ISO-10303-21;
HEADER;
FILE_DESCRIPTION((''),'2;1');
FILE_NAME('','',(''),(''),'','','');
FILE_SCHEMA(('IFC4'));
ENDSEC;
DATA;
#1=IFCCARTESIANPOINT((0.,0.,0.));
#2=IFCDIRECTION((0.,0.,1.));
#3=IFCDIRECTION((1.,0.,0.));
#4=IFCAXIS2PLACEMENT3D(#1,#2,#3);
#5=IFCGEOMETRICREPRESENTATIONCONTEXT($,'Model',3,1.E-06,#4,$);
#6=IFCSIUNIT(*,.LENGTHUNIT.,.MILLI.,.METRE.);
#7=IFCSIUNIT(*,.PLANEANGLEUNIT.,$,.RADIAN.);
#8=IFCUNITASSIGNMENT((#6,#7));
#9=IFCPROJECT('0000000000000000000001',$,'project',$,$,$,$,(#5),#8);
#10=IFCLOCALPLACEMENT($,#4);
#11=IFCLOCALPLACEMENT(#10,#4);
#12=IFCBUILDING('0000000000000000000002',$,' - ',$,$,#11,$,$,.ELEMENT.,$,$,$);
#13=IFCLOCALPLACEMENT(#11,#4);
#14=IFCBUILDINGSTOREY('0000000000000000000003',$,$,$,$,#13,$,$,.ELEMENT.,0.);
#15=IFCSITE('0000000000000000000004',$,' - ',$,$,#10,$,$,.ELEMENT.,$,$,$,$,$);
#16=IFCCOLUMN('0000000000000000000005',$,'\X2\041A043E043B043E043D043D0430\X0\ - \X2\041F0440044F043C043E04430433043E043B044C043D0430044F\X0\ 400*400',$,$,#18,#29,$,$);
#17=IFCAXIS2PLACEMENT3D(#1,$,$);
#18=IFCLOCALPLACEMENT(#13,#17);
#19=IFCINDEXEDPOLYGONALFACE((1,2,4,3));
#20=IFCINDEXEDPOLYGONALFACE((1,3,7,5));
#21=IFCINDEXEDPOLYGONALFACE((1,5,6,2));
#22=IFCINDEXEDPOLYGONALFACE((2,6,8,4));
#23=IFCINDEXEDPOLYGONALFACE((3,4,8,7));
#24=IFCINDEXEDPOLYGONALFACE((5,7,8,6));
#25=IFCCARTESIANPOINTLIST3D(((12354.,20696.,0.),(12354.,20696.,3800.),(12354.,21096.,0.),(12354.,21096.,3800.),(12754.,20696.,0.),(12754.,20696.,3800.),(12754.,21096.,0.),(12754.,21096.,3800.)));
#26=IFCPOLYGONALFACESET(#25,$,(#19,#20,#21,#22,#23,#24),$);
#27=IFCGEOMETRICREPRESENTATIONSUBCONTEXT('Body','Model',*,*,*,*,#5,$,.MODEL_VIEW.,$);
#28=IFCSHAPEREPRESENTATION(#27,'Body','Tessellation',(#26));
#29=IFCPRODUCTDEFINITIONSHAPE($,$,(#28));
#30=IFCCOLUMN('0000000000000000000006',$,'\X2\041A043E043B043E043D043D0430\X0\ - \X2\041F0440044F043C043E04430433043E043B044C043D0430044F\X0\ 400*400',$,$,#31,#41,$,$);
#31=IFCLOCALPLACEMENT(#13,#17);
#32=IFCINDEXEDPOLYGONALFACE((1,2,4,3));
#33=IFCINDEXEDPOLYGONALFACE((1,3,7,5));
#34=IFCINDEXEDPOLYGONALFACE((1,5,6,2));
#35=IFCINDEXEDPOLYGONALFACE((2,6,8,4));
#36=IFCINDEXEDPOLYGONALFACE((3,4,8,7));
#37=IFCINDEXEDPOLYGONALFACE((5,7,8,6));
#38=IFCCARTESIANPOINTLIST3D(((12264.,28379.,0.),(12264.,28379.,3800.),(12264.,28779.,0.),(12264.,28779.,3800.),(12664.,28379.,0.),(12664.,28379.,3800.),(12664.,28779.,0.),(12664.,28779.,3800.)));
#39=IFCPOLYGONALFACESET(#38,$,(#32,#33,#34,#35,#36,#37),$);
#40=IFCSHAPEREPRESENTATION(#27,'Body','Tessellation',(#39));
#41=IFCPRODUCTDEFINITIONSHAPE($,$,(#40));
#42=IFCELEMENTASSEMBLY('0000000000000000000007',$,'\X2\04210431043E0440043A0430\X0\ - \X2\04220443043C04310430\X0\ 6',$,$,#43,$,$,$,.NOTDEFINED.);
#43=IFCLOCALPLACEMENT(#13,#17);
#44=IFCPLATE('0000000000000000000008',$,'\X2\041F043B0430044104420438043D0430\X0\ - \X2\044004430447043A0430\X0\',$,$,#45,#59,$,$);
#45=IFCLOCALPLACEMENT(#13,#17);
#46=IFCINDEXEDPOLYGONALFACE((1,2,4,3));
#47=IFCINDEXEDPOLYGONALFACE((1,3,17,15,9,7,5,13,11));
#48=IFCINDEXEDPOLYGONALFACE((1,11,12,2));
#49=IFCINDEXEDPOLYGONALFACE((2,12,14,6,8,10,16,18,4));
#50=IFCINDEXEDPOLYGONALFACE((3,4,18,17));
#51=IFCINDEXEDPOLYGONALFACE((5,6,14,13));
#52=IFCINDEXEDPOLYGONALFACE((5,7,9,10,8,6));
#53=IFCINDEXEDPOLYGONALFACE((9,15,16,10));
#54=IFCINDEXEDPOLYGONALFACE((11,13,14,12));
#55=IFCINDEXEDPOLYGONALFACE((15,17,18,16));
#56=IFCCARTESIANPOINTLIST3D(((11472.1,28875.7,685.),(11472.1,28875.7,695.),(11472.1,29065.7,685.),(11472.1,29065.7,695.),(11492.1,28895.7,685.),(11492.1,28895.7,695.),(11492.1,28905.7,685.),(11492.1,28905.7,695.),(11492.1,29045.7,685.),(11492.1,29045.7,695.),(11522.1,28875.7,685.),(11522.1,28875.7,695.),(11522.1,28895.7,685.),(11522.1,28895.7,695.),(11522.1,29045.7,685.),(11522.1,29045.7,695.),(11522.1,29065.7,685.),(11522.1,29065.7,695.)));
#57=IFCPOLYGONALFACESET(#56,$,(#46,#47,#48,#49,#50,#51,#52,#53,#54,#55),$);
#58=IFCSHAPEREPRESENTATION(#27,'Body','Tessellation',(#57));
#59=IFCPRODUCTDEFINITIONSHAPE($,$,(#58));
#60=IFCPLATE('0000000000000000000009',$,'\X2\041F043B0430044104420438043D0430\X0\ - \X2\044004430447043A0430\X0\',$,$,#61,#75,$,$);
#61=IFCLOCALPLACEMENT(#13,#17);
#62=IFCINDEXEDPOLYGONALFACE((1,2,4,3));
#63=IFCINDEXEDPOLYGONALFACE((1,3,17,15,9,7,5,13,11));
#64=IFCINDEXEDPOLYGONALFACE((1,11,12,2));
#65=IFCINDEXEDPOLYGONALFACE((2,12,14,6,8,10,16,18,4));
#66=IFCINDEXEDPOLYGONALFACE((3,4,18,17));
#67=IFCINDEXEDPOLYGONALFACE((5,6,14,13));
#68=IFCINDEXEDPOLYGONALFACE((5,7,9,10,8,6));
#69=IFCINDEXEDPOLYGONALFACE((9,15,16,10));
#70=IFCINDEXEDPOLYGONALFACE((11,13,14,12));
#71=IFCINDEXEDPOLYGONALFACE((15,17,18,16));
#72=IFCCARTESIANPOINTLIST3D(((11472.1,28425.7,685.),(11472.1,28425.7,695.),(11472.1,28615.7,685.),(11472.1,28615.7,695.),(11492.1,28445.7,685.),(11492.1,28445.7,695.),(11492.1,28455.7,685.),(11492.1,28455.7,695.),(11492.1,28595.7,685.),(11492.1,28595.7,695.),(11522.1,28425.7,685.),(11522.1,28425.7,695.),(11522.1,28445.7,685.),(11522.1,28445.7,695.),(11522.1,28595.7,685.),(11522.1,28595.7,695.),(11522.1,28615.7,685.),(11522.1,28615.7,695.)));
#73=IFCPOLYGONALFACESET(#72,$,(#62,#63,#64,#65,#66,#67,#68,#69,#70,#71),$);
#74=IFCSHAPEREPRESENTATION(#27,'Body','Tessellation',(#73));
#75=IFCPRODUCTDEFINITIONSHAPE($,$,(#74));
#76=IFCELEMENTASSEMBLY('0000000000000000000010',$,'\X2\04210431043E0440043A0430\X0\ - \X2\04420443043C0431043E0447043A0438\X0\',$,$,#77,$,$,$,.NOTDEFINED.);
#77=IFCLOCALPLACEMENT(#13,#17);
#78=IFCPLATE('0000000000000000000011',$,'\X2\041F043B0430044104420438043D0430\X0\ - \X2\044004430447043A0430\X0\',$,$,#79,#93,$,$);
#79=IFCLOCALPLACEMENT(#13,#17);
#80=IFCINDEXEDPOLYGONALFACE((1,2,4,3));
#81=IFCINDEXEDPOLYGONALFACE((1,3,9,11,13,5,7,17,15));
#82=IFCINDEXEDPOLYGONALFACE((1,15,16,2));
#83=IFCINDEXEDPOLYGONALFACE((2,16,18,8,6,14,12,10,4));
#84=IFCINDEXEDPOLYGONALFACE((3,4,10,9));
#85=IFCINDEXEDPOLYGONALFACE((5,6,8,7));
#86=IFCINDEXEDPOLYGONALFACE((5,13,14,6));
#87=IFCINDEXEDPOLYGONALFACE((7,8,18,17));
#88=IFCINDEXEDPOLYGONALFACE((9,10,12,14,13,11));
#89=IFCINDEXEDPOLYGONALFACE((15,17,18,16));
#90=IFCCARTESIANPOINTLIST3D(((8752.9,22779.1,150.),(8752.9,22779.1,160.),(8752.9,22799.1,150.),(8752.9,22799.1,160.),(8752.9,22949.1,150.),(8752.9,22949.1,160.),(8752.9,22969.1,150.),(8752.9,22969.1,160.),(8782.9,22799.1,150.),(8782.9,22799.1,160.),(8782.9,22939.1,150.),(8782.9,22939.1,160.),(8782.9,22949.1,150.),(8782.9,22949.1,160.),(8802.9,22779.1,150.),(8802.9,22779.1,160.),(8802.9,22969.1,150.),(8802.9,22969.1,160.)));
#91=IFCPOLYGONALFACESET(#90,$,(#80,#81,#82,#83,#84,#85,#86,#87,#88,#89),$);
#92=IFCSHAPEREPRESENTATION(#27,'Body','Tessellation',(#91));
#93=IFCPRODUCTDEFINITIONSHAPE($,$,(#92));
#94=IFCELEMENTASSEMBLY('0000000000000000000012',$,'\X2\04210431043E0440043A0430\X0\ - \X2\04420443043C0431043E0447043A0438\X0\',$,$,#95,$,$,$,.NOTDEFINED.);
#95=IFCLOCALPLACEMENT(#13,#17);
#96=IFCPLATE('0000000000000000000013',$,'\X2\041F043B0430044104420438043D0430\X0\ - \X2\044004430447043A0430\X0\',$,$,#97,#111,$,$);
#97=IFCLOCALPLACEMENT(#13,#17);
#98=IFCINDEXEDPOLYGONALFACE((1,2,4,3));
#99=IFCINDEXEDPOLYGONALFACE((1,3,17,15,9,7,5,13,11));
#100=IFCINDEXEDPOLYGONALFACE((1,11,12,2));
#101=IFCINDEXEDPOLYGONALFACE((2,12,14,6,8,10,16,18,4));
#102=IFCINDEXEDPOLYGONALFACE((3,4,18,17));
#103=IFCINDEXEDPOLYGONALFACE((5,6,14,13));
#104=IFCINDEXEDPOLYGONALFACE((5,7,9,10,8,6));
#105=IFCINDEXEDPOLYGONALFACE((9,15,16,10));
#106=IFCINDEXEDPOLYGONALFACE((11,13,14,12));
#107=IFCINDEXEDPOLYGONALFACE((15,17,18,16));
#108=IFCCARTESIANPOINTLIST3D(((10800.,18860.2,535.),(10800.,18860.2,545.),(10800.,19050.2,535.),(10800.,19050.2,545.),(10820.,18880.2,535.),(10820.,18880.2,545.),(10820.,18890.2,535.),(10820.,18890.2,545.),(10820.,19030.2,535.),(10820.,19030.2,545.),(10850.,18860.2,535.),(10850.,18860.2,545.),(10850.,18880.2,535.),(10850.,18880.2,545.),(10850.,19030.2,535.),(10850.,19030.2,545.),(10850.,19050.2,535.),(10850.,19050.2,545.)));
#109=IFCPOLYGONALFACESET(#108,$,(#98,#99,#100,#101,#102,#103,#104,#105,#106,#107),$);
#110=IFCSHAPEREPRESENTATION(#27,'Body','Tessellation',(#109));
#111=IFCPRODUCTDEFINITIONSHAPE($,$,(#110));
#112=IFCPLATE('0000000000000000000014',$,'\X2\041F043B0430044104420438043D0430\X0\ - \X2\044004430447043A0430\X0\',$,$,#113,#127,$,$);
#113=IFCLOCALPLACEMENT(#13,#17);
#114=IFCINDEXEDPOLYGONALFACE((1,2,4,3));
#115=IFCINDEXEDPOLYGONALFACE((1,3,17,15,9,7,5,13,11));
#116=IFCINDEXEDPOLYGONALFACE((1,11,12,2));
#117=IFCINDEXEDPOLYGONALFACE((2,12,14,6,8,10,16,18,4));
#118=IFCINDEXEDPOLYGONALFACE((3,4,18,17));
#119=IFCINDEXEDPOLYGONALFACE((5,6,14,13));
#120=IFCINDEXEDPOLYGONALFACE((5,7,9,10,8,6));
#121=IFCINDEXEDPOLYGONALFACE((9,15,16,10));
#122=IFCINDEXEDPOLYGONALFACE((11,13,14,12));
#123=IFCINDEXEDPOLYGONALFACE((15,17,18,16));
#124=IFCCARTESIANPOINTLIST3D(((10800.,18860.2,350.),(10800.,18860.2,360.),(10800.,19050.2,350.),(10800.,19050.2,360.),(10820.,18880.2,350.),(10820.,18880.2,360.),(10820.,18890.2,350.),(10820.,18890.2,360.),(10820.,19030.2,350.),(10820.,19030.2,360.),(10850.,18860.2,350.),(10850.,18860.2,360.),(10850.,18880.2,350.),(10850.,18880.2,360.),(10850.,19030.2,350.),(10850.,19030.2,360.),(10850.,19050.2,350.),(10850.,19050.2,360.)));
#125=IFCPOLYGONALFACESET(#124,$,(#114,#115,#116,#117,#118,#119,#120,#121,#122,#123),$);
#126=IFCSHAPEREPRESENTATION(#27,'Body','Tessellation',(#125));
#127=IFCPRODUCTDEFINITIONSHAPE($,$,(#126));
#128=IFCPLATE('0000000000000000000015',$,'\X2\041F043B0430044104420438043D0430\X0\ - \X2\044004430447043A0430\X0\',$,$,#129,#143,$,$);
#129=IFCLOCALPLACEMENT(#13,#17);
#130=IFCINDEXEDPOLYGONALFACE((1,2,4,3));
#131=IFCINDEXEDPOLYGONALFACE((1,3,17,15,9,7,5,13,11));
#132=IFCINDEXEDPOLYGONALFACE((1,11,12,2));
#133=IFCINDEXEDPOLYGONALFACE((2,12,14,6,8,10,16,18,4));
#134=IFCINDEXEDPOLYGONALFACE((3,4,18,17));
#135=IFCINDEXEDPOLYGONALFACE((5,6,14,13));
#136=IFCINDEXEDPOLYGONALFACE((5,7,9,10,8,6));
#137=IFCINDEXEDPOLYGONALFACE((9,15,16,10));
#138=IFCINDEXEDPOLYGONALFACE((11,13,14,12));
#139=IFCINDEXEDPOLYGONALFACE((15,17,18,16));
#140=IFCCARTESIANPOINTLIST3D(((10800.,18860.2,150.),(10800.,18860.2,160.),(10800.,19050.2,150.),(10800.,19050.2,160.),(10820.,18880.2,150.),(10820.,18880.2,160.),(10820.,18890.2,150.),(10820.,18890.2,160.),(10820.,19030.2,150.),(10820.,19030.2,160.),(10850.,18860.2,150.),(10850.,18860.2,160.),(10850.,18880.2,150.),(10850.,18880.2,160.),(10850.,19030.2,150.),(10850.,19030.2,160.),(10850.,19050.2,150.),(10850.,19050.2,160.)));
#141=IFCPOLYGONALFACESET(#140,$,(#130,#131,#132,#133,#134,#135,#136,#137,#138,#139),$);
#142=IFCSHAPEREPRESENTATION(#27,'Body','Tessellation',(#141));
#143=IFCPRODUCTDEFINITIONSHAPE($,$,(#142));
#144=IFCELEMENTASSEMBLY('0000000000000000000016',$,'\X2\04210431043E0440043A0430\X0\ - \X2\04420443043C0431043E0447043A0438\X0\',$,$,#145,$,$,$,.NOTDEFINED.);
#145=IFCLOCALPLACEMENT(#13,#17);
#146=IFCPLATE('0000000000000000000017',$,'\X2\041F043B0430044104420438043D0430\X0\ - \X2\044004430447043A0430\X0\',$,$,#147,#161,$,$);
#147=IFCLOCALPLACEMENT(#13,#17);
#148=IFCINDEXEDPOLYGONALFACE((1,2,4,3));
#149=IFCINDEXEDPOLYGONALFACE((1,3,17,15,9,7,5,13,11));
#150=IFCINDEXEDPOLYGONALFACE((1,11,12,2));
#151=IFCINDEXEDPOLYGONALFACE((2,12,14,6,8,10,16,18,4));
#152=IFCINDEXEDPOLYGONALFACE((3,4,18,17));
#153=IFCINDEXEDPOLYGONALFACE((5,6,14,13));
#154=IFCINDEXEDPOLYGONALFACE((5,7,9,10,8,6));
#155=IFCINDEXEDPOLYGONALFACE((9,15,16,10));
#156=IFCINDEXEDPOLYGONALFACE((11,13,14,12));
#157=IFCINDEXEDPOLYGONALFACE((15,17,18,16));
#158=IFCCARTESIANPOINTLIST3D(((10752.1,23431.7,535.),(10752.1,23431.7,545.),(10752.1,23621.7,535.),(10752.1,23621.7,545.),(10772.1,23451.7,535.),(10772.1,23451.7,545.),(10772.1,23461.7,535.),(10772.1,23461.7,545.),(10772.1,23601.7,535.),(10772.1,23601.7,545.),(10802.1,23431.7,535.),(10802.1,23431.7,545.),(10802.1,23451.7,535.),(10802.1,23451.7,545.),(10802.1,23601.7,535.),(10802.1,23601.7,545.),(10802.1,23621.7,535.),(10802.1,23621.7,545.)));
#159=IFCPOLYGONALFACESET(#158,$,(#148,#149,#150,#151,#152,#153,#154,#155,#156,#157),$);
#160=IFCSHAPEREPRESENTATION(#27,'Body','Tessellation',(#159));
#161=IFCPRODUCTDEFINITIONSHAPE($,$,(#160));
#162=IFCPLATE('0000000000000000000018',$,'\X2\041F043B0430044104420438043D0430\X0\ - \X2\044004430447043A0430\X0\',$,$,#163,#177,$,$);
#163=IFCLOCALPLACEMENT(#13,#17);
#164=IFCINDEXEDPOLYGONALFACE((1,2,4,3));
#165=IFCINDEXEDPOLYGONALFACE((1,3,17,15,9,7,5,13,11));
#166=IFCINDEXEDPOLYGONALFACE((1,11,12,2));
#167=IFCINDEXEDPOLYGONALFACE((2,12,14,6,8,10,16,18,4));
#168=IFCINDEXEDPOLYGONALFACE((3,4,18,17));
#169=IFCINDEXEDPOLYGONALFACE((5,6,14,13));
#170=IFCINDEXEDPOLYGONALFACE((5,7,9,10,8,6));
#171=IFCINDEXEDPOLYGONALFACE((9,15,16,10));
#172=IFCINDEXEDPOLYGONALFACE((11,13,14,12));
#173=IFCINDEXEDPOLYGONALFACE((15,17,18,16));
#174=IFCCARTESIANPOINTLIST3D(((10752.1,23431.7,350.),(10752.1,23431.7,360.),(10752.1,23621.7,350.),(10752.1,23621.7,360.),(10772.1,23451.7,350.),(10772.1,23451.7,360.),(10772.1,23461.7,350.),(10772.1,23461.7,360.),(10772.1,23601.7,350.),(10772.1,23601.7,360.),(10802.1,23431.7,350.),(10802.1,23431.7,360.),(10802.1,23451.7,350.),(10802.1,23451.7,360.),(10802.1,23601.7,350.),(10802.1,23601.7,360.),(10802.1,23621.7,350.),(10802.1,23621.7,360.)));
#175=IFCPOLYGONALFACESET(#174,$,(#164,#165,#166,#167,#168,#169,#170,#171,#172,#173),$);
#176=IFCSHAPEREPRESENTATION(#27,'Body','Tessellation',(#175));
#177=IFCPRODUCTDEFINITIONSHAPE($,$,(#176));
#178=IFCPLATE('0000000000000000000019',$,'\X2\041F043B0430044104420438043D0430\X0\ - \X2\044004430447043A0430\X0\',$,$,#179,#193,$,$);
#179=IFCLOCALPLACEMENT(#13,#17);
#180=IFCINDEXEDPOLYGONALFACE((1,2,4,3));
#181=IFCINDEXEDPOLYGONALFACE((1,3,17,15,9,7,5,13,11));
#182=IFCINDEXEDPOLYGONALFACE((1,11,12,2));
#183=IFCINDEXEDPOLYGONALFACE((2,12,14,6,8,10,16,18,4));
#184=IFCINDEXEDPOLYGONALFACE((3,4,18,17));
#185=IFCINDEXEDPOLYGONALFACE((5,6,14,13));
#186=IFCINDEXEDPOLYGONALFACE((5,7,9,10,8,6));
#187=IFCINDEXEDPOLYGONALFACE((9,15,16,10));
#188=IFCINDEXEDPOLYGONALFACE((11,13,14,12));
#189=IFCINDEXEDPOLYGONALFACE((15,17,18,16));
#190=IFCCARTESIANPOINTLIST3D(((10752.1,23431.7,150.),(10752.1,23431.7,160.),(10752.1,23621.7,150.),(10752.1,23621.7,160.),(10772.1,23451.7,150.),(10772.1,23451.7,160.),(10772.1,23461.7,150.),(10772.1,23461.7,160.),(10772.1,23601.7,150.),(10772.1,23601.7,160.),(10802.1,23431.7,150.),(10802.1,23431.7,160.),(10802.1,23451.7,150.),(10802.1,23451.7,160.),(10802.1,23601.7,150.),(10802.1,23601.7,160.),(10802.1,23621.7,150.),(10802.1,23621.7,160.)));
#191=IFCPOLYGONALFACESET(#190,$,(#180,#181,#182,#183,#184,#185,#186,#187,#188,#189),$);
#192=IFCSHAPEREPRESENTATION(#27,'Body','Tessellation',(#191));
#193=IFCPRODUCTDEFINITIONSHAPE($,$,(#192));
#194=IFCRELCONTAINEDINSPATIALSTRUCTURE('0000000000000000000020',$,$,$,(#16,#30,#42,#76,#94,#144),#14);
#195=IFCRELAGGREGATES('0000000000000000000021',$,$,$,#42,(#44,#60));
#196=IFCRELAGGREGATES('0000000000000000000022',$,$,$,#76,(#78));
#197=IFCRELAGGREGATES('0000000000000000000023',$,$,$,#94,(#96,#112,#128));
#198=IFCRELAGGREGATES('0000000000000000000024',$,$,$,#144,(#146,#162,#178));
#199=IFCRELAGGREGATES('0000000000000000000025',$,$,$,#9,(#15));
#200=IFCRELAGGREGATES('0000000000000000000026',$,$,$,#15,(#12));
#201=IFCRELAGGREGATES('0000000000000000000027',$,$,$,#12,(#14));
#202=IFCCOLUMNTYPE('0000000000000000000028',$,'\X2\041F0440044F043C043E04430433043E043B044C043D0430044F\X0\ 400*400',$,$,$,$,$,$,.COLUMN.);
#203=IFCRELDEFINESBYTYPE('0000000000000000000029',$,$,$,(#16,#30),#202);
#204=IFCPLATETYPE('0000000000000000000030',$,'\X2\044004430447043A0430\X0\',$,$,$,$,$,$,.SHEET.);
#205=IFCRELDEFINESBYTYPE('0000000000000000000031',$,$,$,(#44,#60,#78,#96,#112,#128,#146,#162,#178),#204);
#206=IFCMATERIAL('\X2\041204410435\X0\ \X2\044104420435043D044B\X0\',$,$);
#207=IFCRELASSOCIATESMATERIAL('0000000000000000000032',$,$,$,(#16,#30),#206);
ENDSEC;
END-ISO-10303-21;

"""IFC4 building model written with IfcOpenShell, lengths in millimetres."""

from ifc_helpers import new_model, si_unit, frame, origin_with_axes, place, context, subcontext, project, spatial, line, indexed_curve, outline, extrude, source, transform, mapped, material, type_object, element, aggregate, save


model = new_model("IFC4")

# Units and contexts
model_context = context("Model", 3, precision=1e-06, world=origin_with_axes())
body_context = subcontext(model_context, "Body", "Model", "MODEL_VIEW")
ifc_project = project(units=[si_unit("LENGTHUNIT", "METRE", prefix="MILLI"), si_unit("PLANEANGLEUNIT", "RADIAN")], contexts=[model_context])

# Site, building, storey
site_placement = place(None, origin_with_axes())
site = spatial("IfcSite", under=ifc_project, at=site_placement, Name=" - ", CompositionType="ELEMENT")
building_placement = place(site_placement, origin_with_axes())
building = spatial("IfcBuilding", under=site, at=building_placement, Name=" - ", CompositionType="ELEMENT")
storey_placement = place(building_placement, origin_with_axes())
storey = spatial("IfcBuildingStorey", under=building, at=storey_placement, CompositionType="ELEMENT", Elevation=0.0)

# Columns
ifc_material = material(Name="Все стены")
column_type = type_object("IfcColumnType", Name="Прямоугольная 400*400", PredefinedType="COLUMN")
shared_shape_1 = source(origin_with_axes(), body_context, "Body", "SweptSolid", [
    extrude(outline(indexed_curve([(-200.0, -200.0), (200.0, -200.0), (200.0, 200.0), (-200.0, 200.0)], segments=[line(1, 2), line(2, 3), line(3, 4), line(4, 1)])), origin_with_axes(), (0.0, 0.0, 1.0), 3800.0),
])
for number, where, z_axis, x_axis, name in (
    (1, (12554.0, 20896.0, 0.0), (0.0, 0.0, 1.0), (1.0, 0.0, 0.0), "Колонна - Прямоугольная 400*400"),
    (2, (12464.0, 28579.0, 0.0), (0.0, 0.0, 1.0), (1.0, 0.0, 0.0), "Колонна - Прямоугольная 400*400"),
):
    element("IfcColumn", number, at=place(storey_placement, frame(where, z_axis=z_axis, x_axis=x_axis)), inside=storey, type_object=column_type, material=ifc_material, Name=name, context=body_context, shape_type="MappedRepresentation", body=[
        mapped(shared_shape_1, transform((0.0, 0.0, 0.0), x_axis=(1.0, 0.0, 0.0), y_axis=(0.0, 1.0, 0.0), z_axis=(0.0, 0.0, 1.0), scale=1.0)),
    ])

# Element assembly, plates
assembly_1_placement = place(storey_placement, frame((11537.1, 29195.7, 0.0), z_axis=(0.0, 0.0, 1.0), x_axis=(0.0, -1.0, 0.0)))
assembly_1 = element("IfcElementAssembly", 3, at=assembly_1_placement, inside=storey, Name="Сборка - Тумба 6", PredefinedType="NOTDEFINED")
plate_type_1 = type_object("IfcPlateType", Name="ручка", PredefinedType="SHEET")
shared_shape_2 = source(origin_with_axes(), body_context, "Body", "SweptSolid", [
    extrude(outline(indexed_curve([(-95.0, -25.0), (-75.0, -25.0), (-75.0, 5.0), (-65.0, 5.0), (75.0, 5.0), (75.0, -25.0), (95.0, -25.0), (95.0, 25.0), (-95.0, 25.0)], segments=[line(1, 2), line(2, 3), line(3, 4), line(4, 5), line(5, 6), line(6, 7), line(7, 8), line(8, 9), line(9, 1)])), origin_with_axes(), (0.0, 0.0, 1.0), 10.0),
])
plate_1_placement = place(assembly_1_placement, frame((225.0, -40.0, 685.0), z_axis=(0.0, 0.0, 1.0), x_axis=(-1.0, 0.0, 0.0)))
plate_1 = element("IfcPlate", 4, at=plate_1_placement, type_object=plate_type_1, Name="Пластина - ручка", context=body_context, shape_type="MappedRepresentation", body=[
    mapped(shared_shape_2, transform((0.0, 0.0, 0.0), x_axis=(1.0, 0.0, 0.0), y_axis=(0.0, 1.0, 0.0), z_axis=(0.0, 0.0, 1.0), scale=1.0)),
])
plate_2_placement = place(assembly_1_placement, frame((675.0, -40.0, 685.0), z_axis=(0.0, 0.0, 1.0), x_axis=(-1.0, 0.0, 0.0)))
plate_2 = element("IfcPlate", 5, at=plate_2_placement, type_object=plate_type_1, Name="Пластина - ручка", context=body_context, shape_type="MappedRepresentation", body=[
    mapped(shared_shape_2, transform((0.0, 0.0, 0.0), x_axis=(1.0, 0.0, 0.0), y_axis=(0.0, 1.0, 0.0), z_axis=(0.0, 0.0, 1.0), scale=1.0)),
])
aggregate(assembly_1, [plate_1, plate_2])

# Element assembly, plate
assembly_2_placement = place(storey_placement, frame((8752.9, 22674.1, 0.0), z_axis=(0.0, 0.0, 1.0), x_axis=(0.0, 1.0, 0.0)))
assembly_2 = element("IfcElementAssembly", 6, at=assembly_2_placement, inside=storey, Name="Сборка - тумбочки", PredefinedType="NOTDEFINED")
plate_3_placement = place(assembly_2_placement, frame((200.0, -25.0, 150.0), z_axis=(0.0, 0.0, 1.0), x_axis=(-1.0, 0.0, 0.0)))
plate_3 = element("IfcPlate", 7, at=plate_3_placement, type_object=plate_type_1, Name="Пластина - ручка", context=body_context, shape_type="MappedRepresentation", body=[
    mapped(shared_shape_2, transform((0.0, 0.0, 0.0), x_axis=(1.0, 0.0, 0.0), y_axis=(0.0, 1.0, 0.0), z_axis=(0.0, 0.0, 1.0), scale=1.0)),
])
aggregate(assembly_2, [plate_3])

# Element assemblies, plates
assembly_3_placement = place(storey_placement, frame((10850.0, 19155.2, 0.0), z_axis=(0.0, 0.0, 1.0), x_axis=(0.0, -1.0, 0.0)))
assembly_3 = element("IfcElementAssembly", 8, at=assembly_3_placement, inside=storey, Name="Сборка - тумбочки", PredefinedType="NOTDEFINED")
plate_4_placement = place(assembly_3_placement, frame((200.0, -25.0, 535.0), z_axis=(0.0, 0.0, 1.0), x_axis=(-1.0, 0.0, 0.0)))
plate_4 = element("IfcPlate", 9, at=plate_4_placement, type_object=plate_type_1, Name="Пластина - ручка", context=body_context, shape_type="MappedRepresentation", body=[
    mapped(shared_shape_2, transform((0.0, 0.0, 0.0), x_axis=(1.0, 0.0, 0.0), y_axis=(0.0, 1.0, 0.0), z_axis=(0.0, 0.0, 1.0), scale=1.0)),
])
plate_5_placement = place(assembly_3_placement, frame((200.0, -25.0, 350.0), z_axis=(0.0, 0.0, 1.0), x_axis=(-1.0, 0.0, 0.0)))
plate_5 = element("IfcPlate", 10, at=plate_5_placement, type_object=plate_type_1, Name="Пластина - ручка", context=body_context, shape_type="MappedRepresentation", body=[
    mapped(shared_shape_2, transform((0.0, 0.0, 0.0), x_axis=(1.0, 0.0, 0.0), y_axis=(0.0, 1.0, 0.0), z_axis=(0.0, 0.0, 1.0), scale=1.0)),
])
plate_6_placement = place(assembly_3_placement, frame((200.0, -25.0, 150.0), z_axis=(0.0, 0.0, 1.0), x_axis=(-1.0, 0.0, 0.0)))
plate_6 = element("IfcPlate", 11, at=plate_6_placement, type_object=plate_type_1, Name="Пластина - ручка", context=body_context, shape_type="MappedRepresentation", body=[
    mapped(shared_shape_2, transform((0.0, 0.0, 0.0), x_axis=(1.0, 0.0, 0.0), y_axis=(0.0, 1.0, 0.0), z_axis=(0.0, 0.0, 1.0), scale=1.0)),
])
aggregate(assembly_3, [plate_4, plate_5, plate_6])
assembly_4_placement = place(storey_placement, frame((10802.1, 23726.7, 0.0), z_axis=(0.0, 0.0, 1.0), x_axis=(0.0, -1.0, 0.0)))
assembly_4 = element("IfcElementAssembly", 12, at=assembly_4_placement, inside=storey, Name="Сборка - тумбочки", PredefinedType="NOTDEFINED")
plate_7_placement = place(assembly_4_placement, frame((200.0, -25.0, 535.0), z_axis=(0.0, 0.0, 1.0), x_axis=(-1.0, 0.0, 0.0)))
plate_7 = element("IfcPlate", 13, at=plate_7_placement, type_object=plate_type_1, Name="Пластина - ручка", context=body_context, shape_type="MappedRepresentation", body=[
    mapped(shared_shape_2, transform((0.0, 0.0, 0.0), x_axis=(1.0, 0.0, 0.0), y_axis=(0.0, 1.0, 0.0), z_axis=(0.0, 0.0, 1.0), scale=1.0)),
])
plate_8_placement = place(assembly_4_placement, frame((200.0, -25.0, 350.0), z_axis=(0.0, 0.0, 1.0), x_axis=(-1.0, 0.0, 0.0)))
plate_8 = element("IfcPlate", 14, at=plate_8_placement, type_object=plate_type_1, Name="Пластина - ручка", context=body_context, shape_type="MappedRepresentation", body=[
    mapped(shared_shape_2, transform((0.0, 0.0, 0.0), x_axis=(1.0, 0.0, 0.0), y_axis=(0.0, 1.0, 0.0), z_axis=(0.0, 0.0, 1.0), scale=1.0)),
])
plate_9_placement = place(assembly_4_placement, frame((200.0, -25.0, 150.0), z_axis=(0.0, 0.0, 1.0), x_axis=(-1.0, 0.0, 0.0)))
plate_9 = element("IfcPlate", 15, at=plate_9_placement, type_object=plate_type_1, Name="Пластина - ручка", context=body_context, shape_type="MappedRepresentation", body=[
    mapped(shared_shape_2, transform((0.0, 0.0, 0.0), x_axis=(1.0, 0.0, 0.0), y_axis=(0.0, 1.0, 0.0), z_axis=(0.0, 0.0, 1.0), scale=1.0)),
])
aggregate(assembly_4, [plate_7, plate_8, plate_9])

save(model, "model.ifc")
